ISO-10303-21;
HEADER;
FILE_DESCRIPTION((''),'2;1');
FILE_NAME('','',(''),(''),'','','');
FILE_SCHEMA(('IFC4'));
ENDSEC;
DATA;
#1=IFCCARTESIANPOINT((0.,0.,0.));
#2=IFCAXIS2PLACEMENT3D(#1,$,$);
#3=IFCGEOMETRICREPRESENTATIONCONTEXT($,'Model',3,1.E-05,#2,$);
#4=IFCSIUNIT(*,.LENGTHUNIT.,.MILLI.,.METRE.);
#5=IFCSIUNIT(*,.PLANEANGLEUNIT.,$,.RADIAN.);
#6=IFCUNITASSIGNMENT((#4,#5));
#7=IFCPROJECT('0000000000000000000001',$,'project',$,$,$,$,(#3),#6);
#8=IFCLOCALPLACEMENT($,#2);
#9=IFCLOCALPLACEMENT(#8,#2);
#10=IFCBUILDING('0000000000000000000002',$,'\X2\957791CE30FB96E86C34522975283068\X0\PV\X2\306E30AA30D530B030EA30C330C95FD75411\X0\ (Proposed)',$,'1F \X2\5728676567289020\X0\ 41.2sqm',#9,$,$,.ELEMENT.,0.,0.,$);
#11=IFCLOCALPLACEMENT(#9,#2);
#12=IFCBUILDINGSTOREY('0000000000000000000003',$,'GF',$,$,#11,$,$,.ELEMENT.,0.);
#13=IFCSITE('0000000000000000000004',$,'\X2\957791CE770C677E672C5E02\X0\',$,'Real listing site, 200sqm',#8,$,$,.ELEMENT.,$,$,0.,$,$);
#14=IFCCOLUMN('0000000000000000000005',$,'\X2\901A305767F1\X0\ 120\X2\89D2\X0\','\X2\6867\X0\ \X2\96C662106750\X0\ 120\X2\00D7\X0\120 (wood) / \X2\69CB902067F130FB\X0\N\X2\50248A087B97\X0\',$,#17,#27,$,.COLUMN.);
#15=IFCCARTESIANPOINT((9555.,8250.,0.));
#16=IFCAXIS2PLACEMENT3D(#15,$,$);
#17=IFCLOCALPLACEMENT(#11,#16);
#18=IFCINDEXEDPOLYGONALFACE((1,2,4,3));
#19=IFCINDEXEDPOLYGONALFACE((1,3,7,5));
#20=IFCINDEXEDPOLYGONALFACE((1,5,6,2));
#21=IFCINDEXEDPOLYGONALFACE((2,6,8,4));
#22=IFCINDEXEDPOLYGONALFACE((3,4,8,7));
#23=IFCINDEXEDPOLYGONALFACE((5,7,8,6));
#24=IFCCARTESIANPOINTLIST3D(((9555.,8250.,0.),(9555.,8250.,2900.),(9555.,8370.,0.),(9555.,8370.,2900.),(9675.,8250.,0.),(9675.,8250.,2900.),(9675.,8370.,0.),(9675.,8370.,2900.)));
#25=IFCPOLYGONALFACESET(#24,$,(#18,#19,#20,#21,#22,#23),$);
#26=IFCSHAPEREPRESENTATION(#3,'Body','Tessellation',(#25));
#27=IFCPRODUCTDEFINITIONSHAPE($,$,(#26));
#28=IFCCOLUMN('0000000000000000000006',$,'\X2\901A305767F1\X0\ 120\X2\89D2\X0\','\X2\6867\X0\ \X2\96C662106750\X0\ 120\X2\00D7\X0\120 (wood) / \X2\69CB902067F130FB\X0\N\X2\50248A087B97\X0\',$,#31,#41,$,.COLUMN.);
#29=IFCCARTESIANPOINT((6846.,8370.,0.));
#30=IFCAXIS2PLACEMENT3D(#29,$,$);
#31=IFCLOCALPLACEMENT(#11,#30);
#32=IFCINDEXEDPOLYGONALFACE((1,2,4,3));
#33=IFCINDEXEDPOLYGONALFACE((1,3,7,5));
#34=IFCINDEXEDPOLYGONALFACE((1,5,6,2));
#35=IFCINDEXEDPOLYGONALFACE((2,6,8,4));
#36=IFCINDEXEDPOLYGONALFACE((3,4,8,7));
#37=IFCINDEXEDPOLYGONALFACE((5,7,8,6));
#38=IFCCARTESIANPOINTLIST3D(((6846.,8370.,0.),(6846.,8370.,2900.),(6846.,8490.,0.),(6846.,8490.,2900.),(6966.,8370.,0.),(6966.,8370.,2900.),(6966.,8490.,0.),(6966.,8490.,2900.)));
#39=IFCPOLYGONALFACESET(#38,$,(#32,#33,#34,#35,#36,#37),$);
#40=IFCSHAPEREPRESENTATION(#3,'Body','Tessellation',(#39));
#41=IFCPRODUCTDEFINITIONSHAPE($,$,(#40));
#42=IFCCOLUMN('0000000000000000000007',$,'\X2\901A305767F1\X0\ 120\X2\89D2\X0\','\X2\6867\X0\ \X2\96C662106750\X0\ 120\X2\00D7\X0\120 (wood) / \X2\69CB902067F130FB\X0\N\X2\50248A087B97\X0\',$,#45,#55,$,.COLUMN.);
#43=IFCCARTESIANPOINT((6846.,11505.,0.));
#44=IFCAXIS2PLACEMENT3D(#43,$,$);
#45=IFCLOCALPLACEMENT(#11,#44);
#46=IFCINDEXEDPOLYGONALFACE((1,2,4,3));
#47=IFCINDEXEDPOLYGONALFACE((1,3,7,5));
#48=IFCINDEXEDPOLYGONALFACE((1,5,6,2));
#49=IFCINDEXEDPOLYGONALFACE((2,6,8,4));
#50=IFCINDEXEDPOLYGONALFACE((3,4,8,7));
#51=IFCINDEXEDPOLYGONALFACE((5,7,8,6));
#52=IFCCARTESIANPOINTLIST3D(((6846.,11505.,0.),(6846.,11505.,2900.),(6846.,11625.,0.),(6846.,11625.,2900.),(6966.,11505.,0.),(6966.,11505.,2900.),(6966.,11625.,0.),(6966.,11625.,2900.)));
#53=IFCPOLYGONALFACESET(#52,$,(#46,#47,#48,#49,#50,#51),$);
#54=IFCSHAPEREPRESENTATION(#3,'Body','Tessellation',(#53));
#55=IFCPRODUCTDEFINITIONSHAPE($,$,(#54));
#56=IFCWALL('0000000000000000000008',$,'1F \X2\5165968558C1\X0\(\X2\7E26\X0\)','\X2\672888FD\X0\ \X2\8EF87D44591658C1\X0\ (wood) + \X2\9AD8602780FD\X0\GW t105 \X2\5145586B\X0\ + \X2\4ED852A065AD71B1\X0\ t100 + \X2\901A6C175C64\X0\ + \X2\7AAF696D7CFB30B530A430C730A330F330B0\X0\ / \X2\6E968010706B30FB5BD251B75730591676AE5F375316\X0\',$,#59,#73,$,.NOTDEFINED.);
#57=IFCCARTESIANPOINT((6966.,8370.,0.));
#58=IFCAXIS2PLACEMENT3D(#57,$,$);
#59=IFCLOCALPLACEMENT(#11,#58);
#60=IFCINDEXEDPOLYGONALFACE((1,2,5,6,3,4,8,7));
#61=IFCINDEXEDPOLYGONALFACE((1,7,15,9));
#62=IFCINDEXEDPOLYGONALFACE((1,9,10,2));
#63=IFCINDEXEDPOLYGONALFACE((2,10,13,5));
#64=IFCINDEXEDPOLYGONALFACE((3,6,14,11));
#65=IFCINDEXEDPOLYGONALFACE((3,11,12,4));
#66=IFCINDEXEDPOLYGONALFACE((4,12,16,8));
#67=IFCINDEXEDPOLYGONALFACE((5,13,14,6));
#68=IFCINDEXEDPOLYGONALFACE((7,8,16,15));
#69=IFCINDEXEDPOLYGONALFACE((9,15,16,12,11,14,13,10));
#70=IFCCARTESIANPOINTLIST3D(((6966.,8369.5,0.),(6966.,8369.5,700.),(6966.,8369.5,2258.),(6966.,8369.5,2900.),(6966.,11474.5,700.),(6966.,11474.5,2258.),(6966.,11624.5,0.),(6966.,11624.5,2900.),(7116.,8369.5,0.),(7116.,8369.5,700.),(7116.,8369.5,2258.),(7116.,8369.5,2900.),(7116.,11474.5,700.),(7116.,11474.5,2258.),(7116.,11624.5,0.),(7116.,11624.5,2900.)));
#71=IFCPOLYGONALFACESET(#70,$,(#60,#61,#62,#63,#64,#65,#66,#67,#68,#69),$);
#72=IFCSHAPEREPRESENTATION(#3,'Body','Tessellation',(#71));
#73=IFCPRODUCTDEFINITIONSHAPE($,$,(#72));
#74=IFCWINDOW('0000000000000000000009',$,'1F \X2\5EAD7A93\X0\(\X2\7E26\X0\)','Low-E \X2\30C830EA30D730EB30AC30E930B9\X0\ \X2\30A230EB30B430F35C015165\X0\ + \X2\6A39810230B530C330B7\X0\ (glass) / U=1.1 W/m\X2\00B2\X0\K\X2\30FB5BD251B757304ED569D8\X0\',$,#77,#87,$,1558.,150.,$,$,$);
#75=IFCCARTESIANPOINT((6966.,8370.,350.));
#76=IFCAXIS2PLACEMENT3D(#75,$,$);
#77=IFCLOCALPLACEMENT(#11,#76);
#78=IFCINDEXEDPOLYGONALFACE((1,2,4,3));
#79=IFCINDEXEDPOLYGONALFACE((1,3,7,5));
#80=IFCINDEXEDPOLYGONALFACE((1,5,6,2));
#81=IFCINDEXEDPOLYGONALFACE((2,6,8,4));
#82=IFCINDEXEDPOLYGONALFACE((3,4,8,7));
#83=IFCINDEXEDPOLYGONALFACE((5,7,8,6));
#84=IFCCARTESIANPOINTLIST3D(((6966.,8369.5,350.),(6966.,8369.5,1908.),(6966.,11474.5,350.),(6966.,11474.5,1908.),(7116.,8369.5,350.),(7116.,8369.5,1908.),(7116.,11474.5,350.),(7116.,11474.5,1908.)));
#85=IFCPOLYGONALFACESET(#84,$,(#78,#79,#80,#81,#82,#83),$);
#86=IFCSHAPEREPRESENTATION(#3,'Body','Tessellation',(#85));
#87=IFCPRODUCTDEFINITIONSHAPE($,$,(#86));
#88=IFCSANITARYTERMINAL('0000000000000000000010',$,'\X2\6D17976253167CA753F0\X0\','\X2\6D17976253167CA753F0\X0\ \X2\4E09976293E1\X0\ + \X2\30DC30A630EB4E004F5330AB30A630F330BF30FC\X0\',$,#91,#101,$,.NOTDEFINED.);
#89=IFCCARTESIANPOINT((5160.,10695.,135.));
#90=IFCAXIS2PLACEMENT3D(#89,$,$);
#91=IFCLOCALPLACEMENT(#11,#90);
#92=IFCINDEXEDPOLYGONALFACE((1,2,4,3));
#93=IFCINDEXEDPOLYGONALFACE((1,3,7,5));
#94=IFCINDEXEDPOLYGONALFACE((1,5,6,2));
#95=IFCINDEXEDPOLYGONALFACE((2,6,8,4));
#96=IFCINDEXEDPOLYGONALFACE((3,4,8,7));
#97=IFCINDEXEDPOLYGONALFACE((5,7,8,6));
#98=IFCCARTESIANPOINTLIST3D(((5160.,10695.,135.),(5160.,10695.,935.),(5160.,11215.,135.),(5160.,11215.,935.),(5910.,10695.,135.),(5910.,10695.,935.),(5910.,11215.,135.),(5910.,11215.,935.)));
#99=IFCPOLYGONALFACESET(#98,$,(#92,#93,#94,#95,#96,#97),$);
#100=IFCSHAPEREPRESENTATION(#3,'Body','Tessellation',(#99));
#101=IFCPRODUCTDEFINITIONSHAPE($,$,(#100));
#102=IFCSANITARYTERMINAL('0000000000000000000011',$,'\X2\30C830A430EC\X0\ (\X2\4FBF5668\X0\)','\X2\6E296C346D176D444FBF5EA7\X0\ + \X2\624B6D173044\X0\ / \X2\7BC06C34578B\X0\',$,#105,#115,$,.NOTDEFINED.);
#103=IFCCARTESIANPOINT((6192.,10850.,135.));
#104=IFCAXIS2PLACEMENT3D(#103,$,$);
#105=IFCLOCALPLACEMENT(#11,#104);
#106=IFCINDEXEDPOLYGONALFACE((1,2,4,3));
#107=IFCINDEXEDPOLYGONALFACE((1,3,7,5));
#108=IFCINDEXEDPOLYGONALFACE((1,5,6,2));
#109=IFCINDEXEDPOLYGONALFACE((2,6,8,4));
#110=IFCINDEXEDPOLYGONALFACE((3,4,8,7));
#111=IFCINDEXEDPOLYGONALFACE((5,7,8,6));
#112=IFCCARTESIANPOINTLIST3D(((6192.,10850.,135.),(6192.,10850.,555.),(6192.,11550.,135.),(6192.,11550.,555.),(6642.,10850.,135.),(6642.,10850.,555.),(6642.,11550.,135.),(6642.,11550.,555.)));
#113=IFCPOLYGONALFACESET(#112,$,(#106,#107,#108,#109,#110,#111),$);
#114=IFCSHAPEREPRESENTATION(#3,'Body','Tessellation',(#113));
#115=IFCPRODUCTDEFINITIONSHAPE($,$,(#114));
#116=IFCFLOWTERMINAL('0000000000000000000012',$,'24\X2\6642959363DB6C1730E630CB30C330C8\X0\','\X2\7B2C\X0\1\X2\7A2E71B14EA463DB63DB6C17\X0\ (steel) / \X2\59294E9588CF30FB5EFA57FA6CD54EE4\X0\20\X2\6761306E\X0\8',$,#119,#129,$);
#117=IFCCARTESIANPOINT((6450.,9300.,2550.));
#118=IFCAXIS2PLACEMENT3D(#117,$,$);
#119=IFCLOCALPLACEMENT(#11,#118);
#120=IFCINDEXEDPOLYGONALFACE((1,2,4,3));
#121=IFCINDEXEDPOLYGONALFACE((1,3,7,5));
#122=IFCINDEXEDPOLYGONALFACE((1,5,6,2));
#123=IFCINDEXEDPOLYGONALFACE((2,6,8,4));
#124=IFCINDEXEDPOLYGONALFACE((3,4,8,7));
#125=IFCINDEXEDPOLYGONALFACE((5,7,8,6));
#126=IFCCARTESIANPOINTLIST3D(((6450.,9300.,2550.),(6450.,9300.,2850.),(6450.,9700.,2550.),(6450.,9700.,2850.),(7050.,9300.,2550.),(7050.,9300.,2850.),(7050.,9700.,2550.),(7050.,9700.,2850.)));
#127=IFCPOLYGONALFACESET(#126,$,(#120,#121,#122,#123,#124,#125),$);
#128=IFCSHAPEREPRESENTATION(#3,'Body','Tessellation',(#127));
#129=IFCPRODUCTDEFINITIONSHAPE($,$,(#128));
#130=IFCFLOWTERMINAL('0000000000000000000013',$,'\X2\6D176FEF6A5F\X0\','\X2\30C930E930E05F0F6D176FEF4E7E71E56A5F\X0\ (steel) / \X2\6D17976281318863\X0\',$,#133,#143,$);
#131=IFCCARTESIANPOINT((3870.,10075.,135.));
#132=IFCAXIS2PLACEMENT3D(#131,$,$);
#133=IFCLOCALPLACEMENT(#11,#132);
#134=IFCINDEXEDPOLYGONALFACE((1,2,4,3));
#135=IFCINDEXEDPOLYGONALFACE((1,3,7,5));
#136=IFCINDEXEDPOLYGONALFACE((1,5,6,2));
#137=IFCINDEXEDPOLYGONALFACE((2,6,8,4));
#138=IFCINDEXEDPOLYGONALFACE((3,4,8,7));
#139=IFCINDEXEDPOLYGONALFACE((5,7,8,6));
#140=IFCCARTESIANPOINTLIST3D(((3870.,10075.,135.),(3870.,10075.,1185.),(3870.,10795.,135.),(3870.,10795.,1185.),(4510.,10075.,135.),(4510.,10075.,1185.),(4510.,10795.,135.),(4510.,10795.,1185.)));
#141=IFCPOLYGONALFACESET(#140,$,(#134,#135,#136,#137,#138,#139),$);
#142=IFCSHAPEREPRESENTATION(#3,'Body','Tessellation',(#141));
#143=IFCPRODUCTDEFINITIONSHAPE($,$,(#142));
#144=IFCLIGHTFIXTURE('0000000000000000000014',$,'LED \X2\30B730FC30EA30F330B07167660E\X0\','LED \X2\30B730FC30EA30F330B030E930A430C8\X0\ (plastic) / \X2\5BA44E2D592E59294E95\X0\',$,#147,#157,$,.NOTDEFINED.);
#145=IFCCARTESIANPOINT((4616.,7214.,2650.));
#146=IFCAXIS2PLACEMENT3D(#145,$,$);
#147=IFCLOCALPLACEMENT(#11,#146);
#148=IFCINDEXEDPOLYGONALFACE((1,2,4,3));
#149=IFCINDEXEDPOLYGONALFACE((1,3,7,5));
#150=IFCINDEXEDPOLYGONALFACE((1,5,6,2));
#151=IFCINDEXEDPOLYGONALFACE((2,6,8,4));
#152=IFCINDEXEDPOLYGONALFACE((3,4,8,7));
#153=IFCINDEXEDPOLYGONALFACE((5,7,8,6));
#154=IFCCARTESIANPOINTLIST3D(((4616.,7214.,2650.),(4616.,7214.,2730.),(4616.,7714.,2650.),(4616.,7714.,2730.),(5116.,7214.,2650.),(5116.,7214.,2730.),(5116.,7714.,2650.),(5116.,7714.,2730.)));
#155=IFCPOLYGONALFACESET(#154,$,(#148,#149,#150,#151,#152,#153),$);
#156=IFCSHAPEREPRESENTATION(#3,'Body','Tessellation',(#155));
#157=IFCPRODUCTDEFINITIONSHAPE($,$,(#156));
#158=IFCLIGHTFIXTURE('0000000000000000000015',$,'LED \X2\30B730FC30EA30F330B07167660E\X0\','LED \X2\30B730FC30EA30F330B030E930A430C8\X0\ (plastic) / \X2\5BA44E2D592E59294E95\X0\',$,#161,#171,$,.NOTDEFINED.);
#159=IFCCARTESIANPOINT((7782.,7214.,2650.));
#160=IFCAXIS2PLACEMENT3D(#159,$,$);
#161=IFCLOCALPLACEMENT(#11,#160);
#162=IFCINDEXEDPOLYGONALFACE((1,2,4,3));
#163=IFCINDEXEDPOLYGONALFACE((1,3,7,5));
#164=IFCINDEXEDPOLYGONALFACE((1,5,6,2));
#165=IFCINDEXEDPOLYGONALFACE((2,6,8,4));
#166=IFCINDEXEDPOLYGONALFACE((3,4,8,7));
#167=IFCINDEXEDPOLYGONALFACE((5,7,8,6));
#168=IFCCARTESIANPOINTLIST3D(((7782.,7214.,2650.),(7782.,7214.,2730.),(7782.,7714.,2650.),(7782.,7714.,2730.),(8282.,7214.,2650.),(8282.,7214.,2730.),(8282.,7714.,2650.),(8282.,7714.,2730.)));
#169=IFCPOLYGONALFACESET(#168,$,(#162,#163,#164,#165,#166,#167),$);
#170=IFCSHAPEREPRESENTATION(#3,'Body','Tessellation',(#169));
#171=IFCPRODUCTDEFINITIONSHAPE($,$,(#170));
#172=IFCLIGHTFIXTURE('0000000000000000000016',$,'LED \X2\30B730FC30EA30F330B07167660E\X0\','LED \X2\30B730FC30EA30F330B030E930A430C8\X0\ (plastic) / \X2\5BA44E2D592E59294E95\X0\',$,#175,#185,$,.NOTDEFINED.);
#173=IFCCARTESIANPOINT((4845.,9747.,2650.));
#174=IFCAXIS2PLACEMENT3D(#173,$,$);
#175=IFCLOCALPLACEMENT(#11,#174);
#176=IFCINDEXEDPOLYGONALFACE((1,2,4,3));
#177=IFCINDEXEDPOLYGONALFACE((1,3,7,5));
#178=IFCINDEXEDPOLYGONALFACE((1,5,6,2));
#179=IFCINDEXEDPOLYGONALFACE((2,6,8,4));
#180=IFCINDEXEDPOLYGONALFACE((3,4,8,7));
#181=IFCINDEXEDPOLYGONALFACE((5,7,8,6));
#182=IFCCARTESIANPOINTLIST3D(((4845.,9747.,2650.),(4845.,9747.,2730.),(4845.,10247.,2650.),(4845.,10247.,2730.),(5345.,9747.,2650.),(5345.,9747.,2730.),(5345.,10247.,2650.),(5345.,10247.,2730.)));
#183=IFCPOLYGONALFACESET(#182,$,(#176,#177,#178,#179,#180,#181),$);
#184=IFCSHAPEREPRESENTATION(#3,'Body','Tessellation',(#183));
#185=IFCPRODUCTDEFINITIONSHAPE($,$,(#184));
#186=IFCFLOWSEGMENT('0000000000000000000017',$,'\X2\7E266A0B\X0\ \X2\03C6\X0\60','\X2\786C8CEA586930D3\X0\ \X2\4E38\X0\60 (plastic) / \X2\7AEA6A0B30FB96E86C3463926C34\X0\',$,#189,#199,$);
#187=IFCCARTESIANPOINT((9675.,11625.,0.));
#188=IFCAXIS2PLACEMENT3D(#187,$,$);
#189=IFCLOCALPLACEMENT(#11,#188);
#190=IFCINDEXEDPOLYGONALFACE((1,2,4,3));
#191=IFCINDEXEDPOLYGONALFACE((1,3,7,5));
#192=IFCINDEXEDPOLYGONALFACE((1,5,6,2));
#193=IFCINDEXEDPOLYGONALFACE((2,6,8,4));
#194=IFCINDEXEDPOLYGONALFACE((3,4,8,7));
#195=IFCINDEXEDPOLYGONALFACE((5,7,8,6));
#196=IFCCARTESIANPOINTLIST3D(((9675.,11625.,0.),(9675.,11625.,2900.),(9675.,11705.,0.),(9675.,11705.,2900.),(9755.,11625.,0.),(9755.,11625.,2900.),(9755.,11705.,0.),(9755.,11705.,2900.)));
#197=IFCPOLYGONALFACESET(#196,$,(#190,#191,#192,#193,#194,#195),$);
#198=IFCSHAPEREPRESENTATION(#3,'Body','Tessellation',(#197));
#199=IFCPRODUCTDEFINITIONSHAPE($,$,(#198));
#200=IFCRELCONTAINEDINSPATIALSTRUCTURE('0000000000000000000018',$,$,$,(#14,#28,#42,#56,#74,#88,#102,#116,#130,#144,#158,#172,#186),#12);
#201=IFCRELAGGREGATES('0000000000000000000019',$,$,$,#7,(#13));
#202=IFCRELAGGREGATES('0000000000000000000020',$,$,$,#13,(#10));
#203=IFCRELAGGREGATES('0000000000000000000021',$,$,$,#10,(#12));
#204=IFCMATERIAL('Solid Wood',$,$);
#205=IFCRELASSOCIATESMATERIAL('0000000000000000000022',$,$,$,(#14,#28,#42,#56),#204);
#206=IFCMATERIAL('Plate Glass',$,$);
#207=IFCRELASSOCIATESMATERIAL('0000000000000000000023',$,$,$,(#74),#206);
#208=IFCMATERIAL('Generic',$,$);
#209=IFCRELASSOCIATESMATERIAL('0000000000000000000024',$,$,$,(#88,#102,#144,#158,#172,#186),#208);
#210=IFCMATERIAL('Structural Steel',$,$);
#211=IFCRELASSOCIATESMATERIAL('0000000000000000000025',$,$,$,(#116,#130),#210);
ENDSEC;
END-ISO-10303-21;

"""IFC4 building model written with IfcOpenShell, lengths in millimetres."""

from ifc_helpers import new_model, si_unit, frame, frame_2d, origin, place, context, project, spatial, rectangle, extrude, material, element, fill, save


model = new_model("IFC4")

# Units and contexts
model_context = context("Model", 3, precision=1e-05, world=origin())
ifc_project = project(units=[si_unit("LENGTHUNIT", "METRE", prefix="MILLI"), si_unit("PLANEANGLEUNIT", "RADIAN")], contexts=[model_context])

# Site, building, storey
site_placement = place(None, origin())
site = spatial("IfcSite", under=ifc_project, at=site_placement, Name="長野県松本市", ObjectType="Real listing site, 200sqm", CompositionType="ELEMENT", RefElevation=0.0)
building_placement = place(site_placement, origin())
building = spatial("IfcBuilding", under=site, at=building_placement, Name="長野・雨水利用とPVのオフグリッド志向 (Proposed)", ObjectType="1F 在来木造 41.2sqm", CompositionType="ELEMENT", ElevationOfRefHeight=0.0, ElevationOfTerrain=0.0)
storey_placement = place(building_placement, origin())
storey = spatial("IfcBuildingStorey", under=building, at=storey_placement, Name="GF", CompositionType="ELEMENT", Elevation=0.0)

# Columns
ifc_material_1 = material(Name="Solid Wood")
column_1_placement = place(storey_placement, frame((9555.0, 8250.0, 0.0)))
element("IfcColumn", 1, at=column_1_placement, inside=storey, material=ifc_material_1, Name="通し柱 120角", Description="桧 集成材 120×120 (wood) / 構造柱・N値計算", PredefinedType="COLUMN", context=model_context, shape_type="SweptSolid", body=[
    extrude(rectangle(XDim=120.0, YDim=120.0, at=frame_2d((60.0, 60.0))), frame((9555.0, 8250.0, 0.0)), (0.0, 0.0, 1.0), 2900.0),
])
column_2_placement = place(storey_placement, frame((6846.0, 8370.0, 0.0)))
element("IfcColumn", 2, at=column_2_placement, inside=storey, material=ifc_material_1, Name="通し柱 120角", Description="桧 集成材 120×120 (wood) / 構造柱・N値計算", PredefinedType="COLUMN", context=model_context, shape_type="SweptSolid", body=[
    extrude(rectangle(XDim=120.0, YDim=120.0, at=frame_2d((60.0, 60.0))), frame((6846.0, 8370.0, 0.0)), (0.0, 0.0, 1.0), 2900.0),
])
column_3_placement = place(storey_placement, frame((6846.0, 11505.0, 0.0)))
element("IfcColumn", 3, at=column_3_placement, inside=storey, material=ifc_material_1, Name="通し柱 120角", Description="桧 集成材 120×120 (wood) / 構造柱・N値計算", PredefinedType="COLUMN", context=model_context, shape_type="SweptSolid", body=[
    extrude(rectangle(XDim=120.0, YDim=120.0, at=frame_2d((60.0, 60.0))), frame((6846.0, 11505.0, 0.0)), (0.0, 0.0, 1.0), 2900.0),
])

# Wall, opening, window
wall_1_placement = place(storey_placement, frame((6966.0, 8370.0, 0.0)))
wall_1 = element("IfcWall", 4, at=wall_1_placement, inside=storey, material=ifc_material_1, Name="1F 入隅壁(縦)", Description="木製 軸組外壁 (wood) + 高性能GW t105 充填 + 付加断熱 t100 + 通気層 + 窯業系サイディング / 準耐火・寒冷地外皮強化", PredefinedType="NOTDEFINED", context=model_context, shape_type="SweptSolid", body=[
    extrude(rectangle(XDim=150.0, YDim=3255.0, at=frame_2d((75.0, 1627.0))), frame((6966.0, 8370.0, 0.0)), (0.0, 0.0, 1.0), 2900.0),
])
opening_placement = place(storey_placement, frame((6966.0, 8370.0, 350.0)))
opening = element("IfcOpeningElement", 5, at=opening_placement, cuts=wall_1, PredefinedType="NOTDEFINED", context=model_context, shape_type="SweptSolid", body=[
    extrude(rectangle(XDim=150.0, YDim=3105.0, at=frame_2d((75.0, 1552.0))), frame((6966.0, 8370.0, 350.0)), (0.0, 0.0, 1.0), 1558.0),
])
ifc_material_2 = material(Name="Plate Glass")
window_placement = place(storey_placement, frame((6966.0, 8370.0, 350.0)))
window = element("IfcWindow", 6, at=window_placement, inside=storey, material=ifc_material_2, Name="1F 庭窓(縦)", Description="Low-E トリプルガラス アルゴン封入 + 樹脂サッシ (glass) / U=1.1 W/m²K・寒冷地仕様", OverallHeight=1558.0, OverallWidth=150.0, context=model_context, shape_type="SweptSolid", body=[
    extrude(rectangle(XDim=150.0, YDim=3105.0, at=frame_2d((75.0, 1552.0))), frame((6966.0, 8370.0, 350.0)), (0.0, 0.0, 1.0), 1558.0),
])
fill(opening, window)

# Sanitary terminals
ifc_material_3 = material(Name="Generic")
sanitary_terminal_1_placement = place(storey_placement, frame((5160.0, 10695.0, 135.0)))
element("IfcSanitaryTerminal", 7, at=sanitary_terminal_1_placement, inside=storey, material=ifc_material_3, Name="洗面化粧台", Description="洗面化粧台 三面鏡 + ボウル一体カウンター", PredefinedType="NOTDEFINED", context=model_context, shape_type="SweptSolid", body=[
    extrude(rectangle(XDim=750.0, YDim=520.0, at=frame_2d((375.0, 260.0))), frame((5160.0, 10695.0, 135.0)), (0.0, 0.0, 1.0), 800.0),
])
sanitary_terminal_2_placement = place(storey_placement, frame((6192.0, 10850.0, 135.0)))
element("IfcSanitaryTerminal", 8, at=sanitary_terminal_2_placement, inside=storey, material=ifc_material_3, Name="トイレ (便器)", Description="温水洗浄便座 + 手洗い / 節水型", PredefinedType="NOTDEFINED", context=model_context, shape_type="SweptSolid", body=[
    extrude(rectangle(XDim=450.0, YDim=700.0, at=frame_2d((225.0, 350.0))), frame((6192.0, 10850.0, 135.0)), (0.0, 0.0, 1.0), 420.0),
])

# Flow terminals
ifc_material_4 = material(Name="Structural Steel")
flow_terminal_1_placement = place(storey_placement, frame((6450.0, 9300.0, 2550.0)))
element("IfcFlowTerminal", 9, at=flow_terminal_1_placement, inside=storey, material=ifc_material_4, Name="24時間換気ユニット", Description="第1種熱交換換気 (steel) / 天井裏・建基法令20条の8", context=model_context, shape_type="SweptSolid", body=[
    extrude(rectangle(XDim=600.0, YDim=400.0, at=frame_2d((300.0, 200.0))), frame((6450.0, 9300.0, 2550.0)), (0.0, 0.0, 1.0), 300.0),
])
flow_terminal_2_placement = place(storey_placement, frame((3870.0, 10075.0, 135.0)))
element("IfcFlowTerminal", 10, at=flow_terminal_2_placement, inside=storey, material=ifc_material_4, Name="洗濯機", Description="ドラム式洗濯乾燥機 (steel) / 洗面脱衣", context=model_context, shape_type="SweptSolid", body=[
    extrude(rectangle(XDim=640.0, YDim=720.0, at=frame_2d((320.0, 360.0))), frame((3870.0, 10075.0, 135.0)), (0.0, 0.0, 1.0), 1050.0),
])

# Light fixtures
light_fixture_1_placement = place(storey_placement, frame((4616.0, 7214.0, 2650.0)))
element("IfcLightFixture", 11, at=light_fixture_1_placement, inside=storey, material=ifc_material_3, Name="LED シーリング照明", Description="LED シーリングライト (plastic) / 室中央天井", PredefinedType="NOTDEFINED", context=model_context, shape_type="SweptSolid", body=[
    extrude(rectangle(XDim=500.0, YDim=500.0, at=frame_2d((250.0, 250.0))), frame((4616.0, 7214.0, 2650.0)), (0.0, 0.0, 1.0), 80.0),
])
light_fixture_2_placement = place(storey_placement, frame((7782.0, 7214.0, 2650.0)))
element("IfcLightFixture", 12, at=light_fixture_2_placement, inside=storey, material=ifc_material_3, Name="LED シーリング照明", Description="LED シーリングライト (plastic) / 室中央天井", PredefinedType="NOTDEFINED", context=model_context, shape_type="SweptSolid", body=[
    extrude(rectangle(XDim=500.0, YDim=500.0, at=frame_2d((250.0, 250.0))), frame((7782.0, 7214.0, 2650.0)), (0.0, 0.0, 1.0), 80.0),
])
light_fixture_3_placement = place(storey_placement, frame((4845.0, 9747.0, 2650.0)))
element("IfcLightFixture", 13, at=light_fixture_3_placement, inside=storey, material=ifc_material_3, Name="LED シーリング照明", Description="LED シーリングライト (plastic) / 室中央天井", PredefinedType="NOTDEFINED", context=model_context, shape_type="SweptSolid", body=[
    extrude(rectangle(XDim=500.0, YDim=500.0, at=frame_2d((250.0, 250.0))), frame((4845.0, 9747.0, 2650.0)), (0.0, 0.0, 1.0), 80.0),
])

# Flow segment
flow_segment_placement = place(storey_placement, frame((9675.0, 11625.0, 0.0)))
element("IfcFlowSegment", 14, at=flow_segment_placement, inside=storey, material=ifc_material_3, Name="縦樋 φ60", Description="硬質塩ビ 丸60 (plastic) / 竪樋・雨水排水", context=model_context, shape_type="SweptSolid", body=[
    extrude(rectangle(XDim=80.0, YDim=80.0, at=frame_2d((40.0, 40.0))), frame((9675.0, 11625.0, 0.0)), (0.0, 0.0, 1.0), 2900.0),
])

save(model, "model.ifc")
